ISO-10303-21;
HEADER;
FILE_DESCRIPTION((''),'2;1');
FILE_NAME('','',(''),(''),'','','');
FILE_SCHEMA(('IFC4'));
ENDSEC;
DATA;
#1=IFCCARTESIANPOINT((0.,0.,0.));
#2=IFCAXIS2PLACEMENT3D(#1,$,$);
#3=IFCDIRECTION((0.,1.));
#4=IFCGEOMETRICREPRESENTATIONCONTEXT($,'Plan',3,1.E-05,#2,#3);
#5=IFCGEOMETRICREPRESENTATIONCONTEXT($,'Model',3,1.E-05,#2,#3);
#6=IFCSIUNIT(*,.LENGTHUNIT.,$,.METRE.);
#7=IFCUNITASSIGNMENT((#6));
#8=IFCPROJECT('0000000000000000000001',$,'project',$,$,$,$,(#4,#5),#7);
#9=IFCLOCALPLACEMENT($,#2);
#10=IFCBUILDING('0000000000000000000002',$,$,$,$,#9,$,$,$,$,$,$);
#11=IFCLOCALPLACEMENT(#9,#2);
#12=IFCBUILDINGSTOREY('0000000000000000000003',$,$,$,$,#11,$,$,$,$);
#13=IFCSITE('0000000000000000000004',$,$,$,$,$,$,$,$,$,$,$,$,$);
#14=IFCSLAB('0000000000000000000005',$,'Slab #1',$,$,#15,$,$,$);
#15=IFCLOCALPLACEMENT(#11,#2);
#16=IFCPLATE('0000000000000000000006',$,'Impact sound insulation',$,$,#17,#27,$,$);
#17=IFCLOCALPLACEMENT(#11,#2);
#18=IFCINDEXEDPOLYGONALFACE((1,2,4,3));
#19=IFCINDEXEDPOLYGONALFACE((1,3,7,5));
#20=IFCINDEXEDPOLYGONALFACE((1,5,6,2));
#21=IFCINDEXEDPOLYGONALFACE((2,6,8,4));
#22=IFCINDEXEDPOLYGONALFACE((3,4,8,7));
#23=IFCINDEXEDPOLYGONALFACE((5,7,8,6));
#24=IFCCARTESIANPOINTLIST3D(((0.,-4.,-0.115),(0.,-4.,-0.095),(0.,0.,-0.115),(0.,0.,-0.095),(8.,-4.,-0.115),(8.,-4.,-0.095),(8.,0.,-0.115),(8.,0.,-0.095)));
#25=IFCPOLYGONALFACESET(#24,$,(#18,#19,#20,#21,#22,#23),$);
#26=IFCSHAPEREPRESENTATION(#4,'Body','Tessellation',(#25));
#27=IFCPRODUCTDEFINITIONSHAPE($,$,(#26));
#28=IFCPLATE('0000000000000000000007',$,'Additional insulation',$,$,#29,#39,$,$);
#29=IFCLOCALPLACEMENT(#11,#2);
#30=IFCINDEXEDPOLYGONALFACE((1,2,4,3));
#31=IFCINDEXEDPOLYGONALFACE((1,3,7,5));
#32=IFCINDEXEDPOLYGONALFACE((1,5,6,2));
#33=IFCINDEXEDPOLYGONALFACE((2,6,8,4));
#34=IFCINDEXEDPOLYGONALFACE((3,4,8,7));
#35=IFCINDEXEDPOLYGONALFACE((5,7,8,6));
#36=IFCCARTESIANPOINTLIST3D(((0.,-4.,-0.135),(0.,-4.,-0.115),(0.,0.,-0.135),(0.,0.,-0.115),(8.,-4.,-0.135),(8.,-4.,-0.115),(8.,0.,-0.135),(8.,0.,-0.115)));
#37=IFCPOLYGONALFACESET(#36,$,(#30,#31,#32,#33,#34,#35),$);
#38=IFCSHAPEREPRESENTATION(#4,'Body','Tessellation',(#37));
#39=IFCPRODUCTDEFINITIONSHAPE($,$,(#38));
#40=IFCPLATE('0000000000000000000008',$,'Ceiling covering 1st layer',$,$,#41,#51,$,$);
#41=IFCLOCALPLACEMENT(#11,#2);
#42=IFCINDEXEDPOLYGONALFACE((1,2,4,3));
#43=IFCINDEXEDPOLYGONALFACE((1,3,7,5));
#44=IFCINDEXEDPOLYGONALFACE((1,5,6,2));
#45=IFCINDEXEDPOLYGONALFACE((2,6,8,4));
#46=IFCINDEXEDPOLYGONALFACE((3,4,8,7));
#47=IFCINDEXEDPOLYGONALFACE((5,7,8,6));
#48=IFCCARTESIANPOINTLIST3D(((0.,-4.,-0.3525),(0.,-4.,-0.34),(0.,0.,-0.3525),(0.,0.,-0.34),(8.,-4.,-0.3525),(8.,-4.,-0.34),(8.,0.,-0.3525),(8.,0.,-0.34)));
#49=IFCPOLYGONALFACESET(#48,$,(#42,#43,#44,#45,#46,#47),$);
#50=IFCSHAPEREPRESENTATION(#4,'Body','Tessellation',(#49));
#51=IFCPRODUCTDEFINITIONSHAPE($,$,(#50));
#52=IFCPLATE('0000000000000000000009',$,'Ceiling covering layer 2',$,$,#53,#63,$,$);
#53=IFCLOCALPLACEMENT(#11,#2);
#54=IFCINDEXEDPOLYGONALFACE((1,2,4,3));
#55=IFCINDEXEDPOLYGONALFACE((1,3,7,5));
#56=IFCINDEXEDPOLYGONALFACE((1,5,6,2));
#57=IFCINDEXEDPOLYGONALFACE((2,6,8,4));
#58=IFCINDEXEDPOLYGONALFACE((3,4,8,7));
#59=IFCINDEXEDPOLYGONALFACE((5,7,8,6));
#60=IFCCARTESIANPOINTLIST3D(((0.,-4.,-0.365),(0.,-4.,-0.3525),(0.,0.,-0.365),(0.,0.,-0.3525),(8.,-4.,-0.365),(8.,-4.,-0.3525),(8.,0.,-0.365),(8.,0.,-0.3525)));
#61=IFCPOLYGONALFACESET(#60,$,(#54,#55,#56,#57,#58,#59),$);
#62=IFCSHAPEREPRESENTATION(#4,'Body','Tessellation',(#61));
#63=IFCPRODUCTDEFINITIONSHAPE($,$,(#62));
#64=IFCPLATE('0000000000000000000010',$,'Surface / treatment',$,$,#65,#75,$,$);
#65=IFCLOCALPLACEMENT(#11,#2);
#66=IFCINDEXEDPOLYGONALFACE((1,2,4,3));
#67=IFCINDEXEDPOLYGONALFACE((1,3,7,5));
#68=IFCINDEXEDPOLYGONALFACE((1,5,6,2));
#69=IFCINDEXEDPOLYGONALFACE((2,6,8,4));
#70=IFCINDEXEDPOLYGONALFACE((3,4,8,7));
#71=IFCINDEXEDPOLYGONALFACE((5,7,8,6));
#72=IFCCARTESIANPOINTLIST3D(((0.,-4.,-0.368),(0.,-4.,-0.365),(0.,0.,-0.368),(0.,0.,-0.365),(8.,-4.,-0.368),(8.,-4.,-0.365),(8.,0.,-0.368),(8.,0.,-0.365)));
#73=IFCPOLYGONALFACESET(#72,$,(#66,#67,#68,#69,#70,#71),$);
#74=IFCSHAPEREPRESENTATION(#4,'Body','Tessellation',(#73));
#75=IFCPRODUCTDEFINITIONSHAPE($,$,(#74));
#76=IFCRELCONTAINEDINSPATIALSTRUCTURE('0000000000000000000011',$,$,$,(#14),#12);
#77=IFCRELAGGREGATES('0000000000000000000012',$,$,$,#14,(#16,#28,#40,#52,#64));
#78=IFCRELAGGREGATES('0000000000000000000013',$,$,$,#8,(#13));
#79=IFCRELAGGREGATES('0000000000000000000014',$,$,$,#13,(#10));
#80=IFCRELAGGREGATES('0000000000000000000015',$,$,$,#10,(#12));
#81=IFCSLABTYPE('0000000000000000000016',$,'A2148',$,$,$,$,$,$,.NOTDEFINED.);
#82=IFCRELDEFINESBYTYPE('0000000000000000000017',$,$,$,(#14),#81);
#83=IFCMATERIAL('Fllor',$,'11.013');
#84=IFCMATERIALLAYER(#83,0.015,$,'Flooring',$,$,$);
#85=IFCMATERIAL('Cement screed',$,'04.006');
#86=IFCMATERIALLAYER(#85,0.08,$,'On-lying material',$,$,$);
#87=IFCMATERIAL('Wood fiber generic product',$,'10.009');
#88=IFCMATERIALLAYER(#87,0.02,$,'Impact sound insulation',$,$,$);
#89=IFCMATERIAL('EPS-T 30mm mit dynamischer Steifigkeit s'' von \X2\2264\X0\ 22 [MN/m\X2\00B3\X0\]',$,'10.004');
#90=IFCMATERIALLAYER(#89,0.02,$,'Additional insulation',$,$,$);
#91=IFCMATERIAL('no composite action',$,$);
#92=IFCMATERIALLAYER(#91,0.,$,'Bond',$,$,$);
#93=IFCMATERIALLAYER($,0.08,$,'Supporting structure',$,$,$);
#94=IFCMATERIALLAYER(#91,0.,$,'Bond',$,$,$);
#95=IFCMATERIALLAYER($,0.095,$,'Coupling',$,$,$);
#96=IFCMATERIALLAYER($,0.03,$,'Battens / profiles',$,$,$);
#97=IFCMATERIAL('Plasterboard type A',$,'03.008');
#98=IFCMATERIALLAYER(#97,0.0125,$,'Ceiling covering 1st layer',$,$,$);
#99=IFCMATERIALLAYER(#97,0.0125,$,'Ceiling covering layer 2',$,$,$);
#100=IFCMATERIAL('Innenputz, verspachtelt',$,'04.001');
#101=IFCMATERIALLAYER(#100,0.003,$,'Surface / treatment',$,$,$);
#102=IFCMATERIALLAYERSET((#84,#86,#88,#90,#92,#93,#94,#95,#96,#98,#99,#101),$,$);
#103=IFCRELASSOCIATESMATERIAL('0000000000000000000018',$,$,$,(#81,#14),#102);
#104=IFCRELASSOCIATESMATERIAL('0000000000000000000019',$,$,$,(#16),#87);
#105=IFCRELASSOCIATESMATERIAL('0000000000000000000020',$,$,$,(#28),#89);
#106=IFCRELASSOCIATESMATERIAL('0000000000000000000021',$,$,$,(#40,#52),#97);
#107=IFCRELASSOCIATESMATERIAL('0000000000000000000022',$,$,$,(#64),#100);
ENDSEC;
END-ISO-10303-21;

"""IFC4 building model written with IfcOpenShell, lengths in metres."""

from ifc_helpers import new_model, si_unit, direction, frame, frame_2d, origin, place, context, project, spatial, rectangle, extrude, material, layer, layer_set, type_object, element, aggregate, save


model = new_model("IFC4")

# Units and contexts
plan_context = context("Plan", 3, precision=1e-05, world=origin(), true_north=direction((0.0, 1.0)))
model_context = context("Model", 3, precision=1e-05, world=origin(), true_north=direction((0.0, 1.0)))
ifc_project = project(units=[si_unit("LENGTHUNIT", "METRE")], contexts=[plan_context, model_context])

# Site, building, storey
site = spatial("IfcSite", under=ifc_project)
building_placement = place(None, origin())
building = spatial("IfcBuilding", under=site, at=building_placement)
storey_placement = place(building_placement, origin())
storey = spatial("IfcBuildingStorey", under=building, at=storey_placement)

# Slab, plates
ifc_material_1 = material(Name="Fllor", Category="11.013")
ifc_layer_1 = layer(ifc_material_1, 0.015, Name="Flooring")
ifc_material_2 = material(Name="Cement screed", Category="04.006")
ifc_layer_2 = layer(ifc_material_2, 0.08, Name="On-lying material")
ifc_material_3 = material(Name="Wood fiber generic product", Category="10.009")
ifc_layer_3 = layer(ifc_material_3, 0.02, Name="Impact sound insulation")
ifc_material_4 = material(Name="EPS-T 30mm mit dynamischer Steifigkeit s' von ≤ 22 [MN/m³]", Category="10.004")
ifc_layer_4 = layer(ifc_material_4, 0.02, Name="Additional insulation")
ifc_material_5 = material(Name="no composite action")
ifc_layer_5 = layer(ifc_material_5, 0.0, Name="Bond")
ifc_layer_6 = layer(None, 0.08, Name="Supporting structure")
ifc_layer_7 = layer(ifc_material_5, 0.0, Name="Bond")
ifc_layer_8 = layer(None, 0.095, Name="Coupling")
ifc_layer_9 = layer(None, 0.03, Name="Battens / profiles")
ifc_material_6 = material(Name="Plasterboard type A", Category="03.008")
ifc_layer_10 = layer(ifc_material_6, 0.0125, Name="Ceiling covering 1st layer")
ifc_layer_11 = layer(ifc_material_6, 0.0125, Name="Ceiling covering layer 2")
ifc_material_7 = material(Name="Innenputz, verspachtelt", Category="04.001")
ifc_layer_12 = layer(ifc_material_7, 0.003, Name="Surface / treatment")
ifc_layer_set = layer_set([ifc_layer_1, ifc_layer_2, ifc_layer_3, ifc_layer_4, ifc_layer_5, ifc_layer_6, ifc_layer_7, ifc_layer_8, ifc_layer_9, ifc_layer_10, ifc_layer_11, ifc_layer_12])
slab_type = type_object("IfcSlabType", Name="A2148", PredefinedType="NOTDEFINED", material=ifc_layer_set)
slab_placement = place(None, frame((0.0, 0.0, 0.0), z_axis=(0.0, 0.0, -1.0), x_axis=(1.0, 0.0, 0.0)))
slab = element("IfcSlab", 1, at=slab_placement, inside=storey, type_object=slab_type, material=ifc_layer_set, Name="Slab #1")
plate_1_placement = place(slab_placement, origin())
plate_1 = element("IfcPlate", 2, at=plate_1_placement, material=ifc_material_3, Name="Impact sound insulation", context=plan_context, shape_type="SweptSolid", body=[
    extrude(rectangle(XDim=8.0, YDim=4.0, at=frame_2d((4.0, 2.0), x_axis=(1.0, 0.0))), frame((0.0, 0.0, 0.095), z_axis=(0.0, 0.0, 1.0), x_axis=(1.0, 0.0, 0.0)), (0.0, 0.0, 1.0), 0.02),
])
plate_2_placement = place(slab_placement, origin())
plate_2 = element("IfcPlate", 3, at=plate_2_placement, material=ifc_material_4, Name="Additional insulation", context=plan_context, shape_type="SweptSolid", body=[
    extrude(rectangle(XDim=8.0, YDim=4.0, at=frame_2d((4.0, 2.0), x_axis=(1.0, 0.0))), frame((0.0, 0.0, 0.115), z_axis=(0.0, 0.0, 1.0), x_axis=(1.0, 0.0, 0.0)), (0.0, 0.0, 1.0), 0.02),
])
plate_3_placement = place(slab_placement, origin())
plate_3 = element("IfcPlate", 4, at=plate_3_placement, material=ifc_material_6, Name="Ceiling covering 1st layer", context=plan_context, shape_type="SweptSolid", body=[
    extrude(rectangle(XDim=8.0, YDim=4.0, at=frame_2d((4.0, 2.0), x_axis=(1.0, 0.0))), frame((0.0, 0.0, 0.34), z_axis=(0.0, 0.0, 1.0), x_axis=(1.0, 0.0, 0.0)), (0.0, 0.0, 1.0), 0.0125),
])
plate_4_placement = place(slab_placement, origin())
plate_4 = element("IfcPlate", 5, at=plate_4_placement, material=ifc_material_6, Name="Ceiling covering layer 2", context=plan_context, shape_type="SweptSolid", body=[
    extrude(rectangle(XDim=8.0, YDim=4.0, at=frame_2d((4.0, 2.0), x_axis=(1.0, 0.0))), frame((0.0, 0.0, 0.3525), z_axis=(0.0, 0.0, 1.0), x_axis=(1.0, 0.0, 0.0)), (0.0, 0.0, 1.0), 0.0125),
])
plate_5_placement = place(slab_placement, origin())
plate_5 = element("IfcPlate", 6, at=plate_5_placement, material=ifc_material_7, Name="Surface / treatment", context=plan_context, shape_type="SweptSolid", body=[
    extrude(rectangle(XDim=8.0, YDim=4.0, at=frame_2d((4.0, 2.0), x_axis=(1.0, 0.0))), frame((0.0, 0.0, 0.365), z_axis=(0.0, 0.0, 1.0), x_axis=(1.0, 0.0, 0.0)), (0.0, 0.0, 1.0), 0.003),
])
aggregate(slab, [plate_1, plate_2, plate_3, plate_4, plate_5])

save(model, "model.ifc")
